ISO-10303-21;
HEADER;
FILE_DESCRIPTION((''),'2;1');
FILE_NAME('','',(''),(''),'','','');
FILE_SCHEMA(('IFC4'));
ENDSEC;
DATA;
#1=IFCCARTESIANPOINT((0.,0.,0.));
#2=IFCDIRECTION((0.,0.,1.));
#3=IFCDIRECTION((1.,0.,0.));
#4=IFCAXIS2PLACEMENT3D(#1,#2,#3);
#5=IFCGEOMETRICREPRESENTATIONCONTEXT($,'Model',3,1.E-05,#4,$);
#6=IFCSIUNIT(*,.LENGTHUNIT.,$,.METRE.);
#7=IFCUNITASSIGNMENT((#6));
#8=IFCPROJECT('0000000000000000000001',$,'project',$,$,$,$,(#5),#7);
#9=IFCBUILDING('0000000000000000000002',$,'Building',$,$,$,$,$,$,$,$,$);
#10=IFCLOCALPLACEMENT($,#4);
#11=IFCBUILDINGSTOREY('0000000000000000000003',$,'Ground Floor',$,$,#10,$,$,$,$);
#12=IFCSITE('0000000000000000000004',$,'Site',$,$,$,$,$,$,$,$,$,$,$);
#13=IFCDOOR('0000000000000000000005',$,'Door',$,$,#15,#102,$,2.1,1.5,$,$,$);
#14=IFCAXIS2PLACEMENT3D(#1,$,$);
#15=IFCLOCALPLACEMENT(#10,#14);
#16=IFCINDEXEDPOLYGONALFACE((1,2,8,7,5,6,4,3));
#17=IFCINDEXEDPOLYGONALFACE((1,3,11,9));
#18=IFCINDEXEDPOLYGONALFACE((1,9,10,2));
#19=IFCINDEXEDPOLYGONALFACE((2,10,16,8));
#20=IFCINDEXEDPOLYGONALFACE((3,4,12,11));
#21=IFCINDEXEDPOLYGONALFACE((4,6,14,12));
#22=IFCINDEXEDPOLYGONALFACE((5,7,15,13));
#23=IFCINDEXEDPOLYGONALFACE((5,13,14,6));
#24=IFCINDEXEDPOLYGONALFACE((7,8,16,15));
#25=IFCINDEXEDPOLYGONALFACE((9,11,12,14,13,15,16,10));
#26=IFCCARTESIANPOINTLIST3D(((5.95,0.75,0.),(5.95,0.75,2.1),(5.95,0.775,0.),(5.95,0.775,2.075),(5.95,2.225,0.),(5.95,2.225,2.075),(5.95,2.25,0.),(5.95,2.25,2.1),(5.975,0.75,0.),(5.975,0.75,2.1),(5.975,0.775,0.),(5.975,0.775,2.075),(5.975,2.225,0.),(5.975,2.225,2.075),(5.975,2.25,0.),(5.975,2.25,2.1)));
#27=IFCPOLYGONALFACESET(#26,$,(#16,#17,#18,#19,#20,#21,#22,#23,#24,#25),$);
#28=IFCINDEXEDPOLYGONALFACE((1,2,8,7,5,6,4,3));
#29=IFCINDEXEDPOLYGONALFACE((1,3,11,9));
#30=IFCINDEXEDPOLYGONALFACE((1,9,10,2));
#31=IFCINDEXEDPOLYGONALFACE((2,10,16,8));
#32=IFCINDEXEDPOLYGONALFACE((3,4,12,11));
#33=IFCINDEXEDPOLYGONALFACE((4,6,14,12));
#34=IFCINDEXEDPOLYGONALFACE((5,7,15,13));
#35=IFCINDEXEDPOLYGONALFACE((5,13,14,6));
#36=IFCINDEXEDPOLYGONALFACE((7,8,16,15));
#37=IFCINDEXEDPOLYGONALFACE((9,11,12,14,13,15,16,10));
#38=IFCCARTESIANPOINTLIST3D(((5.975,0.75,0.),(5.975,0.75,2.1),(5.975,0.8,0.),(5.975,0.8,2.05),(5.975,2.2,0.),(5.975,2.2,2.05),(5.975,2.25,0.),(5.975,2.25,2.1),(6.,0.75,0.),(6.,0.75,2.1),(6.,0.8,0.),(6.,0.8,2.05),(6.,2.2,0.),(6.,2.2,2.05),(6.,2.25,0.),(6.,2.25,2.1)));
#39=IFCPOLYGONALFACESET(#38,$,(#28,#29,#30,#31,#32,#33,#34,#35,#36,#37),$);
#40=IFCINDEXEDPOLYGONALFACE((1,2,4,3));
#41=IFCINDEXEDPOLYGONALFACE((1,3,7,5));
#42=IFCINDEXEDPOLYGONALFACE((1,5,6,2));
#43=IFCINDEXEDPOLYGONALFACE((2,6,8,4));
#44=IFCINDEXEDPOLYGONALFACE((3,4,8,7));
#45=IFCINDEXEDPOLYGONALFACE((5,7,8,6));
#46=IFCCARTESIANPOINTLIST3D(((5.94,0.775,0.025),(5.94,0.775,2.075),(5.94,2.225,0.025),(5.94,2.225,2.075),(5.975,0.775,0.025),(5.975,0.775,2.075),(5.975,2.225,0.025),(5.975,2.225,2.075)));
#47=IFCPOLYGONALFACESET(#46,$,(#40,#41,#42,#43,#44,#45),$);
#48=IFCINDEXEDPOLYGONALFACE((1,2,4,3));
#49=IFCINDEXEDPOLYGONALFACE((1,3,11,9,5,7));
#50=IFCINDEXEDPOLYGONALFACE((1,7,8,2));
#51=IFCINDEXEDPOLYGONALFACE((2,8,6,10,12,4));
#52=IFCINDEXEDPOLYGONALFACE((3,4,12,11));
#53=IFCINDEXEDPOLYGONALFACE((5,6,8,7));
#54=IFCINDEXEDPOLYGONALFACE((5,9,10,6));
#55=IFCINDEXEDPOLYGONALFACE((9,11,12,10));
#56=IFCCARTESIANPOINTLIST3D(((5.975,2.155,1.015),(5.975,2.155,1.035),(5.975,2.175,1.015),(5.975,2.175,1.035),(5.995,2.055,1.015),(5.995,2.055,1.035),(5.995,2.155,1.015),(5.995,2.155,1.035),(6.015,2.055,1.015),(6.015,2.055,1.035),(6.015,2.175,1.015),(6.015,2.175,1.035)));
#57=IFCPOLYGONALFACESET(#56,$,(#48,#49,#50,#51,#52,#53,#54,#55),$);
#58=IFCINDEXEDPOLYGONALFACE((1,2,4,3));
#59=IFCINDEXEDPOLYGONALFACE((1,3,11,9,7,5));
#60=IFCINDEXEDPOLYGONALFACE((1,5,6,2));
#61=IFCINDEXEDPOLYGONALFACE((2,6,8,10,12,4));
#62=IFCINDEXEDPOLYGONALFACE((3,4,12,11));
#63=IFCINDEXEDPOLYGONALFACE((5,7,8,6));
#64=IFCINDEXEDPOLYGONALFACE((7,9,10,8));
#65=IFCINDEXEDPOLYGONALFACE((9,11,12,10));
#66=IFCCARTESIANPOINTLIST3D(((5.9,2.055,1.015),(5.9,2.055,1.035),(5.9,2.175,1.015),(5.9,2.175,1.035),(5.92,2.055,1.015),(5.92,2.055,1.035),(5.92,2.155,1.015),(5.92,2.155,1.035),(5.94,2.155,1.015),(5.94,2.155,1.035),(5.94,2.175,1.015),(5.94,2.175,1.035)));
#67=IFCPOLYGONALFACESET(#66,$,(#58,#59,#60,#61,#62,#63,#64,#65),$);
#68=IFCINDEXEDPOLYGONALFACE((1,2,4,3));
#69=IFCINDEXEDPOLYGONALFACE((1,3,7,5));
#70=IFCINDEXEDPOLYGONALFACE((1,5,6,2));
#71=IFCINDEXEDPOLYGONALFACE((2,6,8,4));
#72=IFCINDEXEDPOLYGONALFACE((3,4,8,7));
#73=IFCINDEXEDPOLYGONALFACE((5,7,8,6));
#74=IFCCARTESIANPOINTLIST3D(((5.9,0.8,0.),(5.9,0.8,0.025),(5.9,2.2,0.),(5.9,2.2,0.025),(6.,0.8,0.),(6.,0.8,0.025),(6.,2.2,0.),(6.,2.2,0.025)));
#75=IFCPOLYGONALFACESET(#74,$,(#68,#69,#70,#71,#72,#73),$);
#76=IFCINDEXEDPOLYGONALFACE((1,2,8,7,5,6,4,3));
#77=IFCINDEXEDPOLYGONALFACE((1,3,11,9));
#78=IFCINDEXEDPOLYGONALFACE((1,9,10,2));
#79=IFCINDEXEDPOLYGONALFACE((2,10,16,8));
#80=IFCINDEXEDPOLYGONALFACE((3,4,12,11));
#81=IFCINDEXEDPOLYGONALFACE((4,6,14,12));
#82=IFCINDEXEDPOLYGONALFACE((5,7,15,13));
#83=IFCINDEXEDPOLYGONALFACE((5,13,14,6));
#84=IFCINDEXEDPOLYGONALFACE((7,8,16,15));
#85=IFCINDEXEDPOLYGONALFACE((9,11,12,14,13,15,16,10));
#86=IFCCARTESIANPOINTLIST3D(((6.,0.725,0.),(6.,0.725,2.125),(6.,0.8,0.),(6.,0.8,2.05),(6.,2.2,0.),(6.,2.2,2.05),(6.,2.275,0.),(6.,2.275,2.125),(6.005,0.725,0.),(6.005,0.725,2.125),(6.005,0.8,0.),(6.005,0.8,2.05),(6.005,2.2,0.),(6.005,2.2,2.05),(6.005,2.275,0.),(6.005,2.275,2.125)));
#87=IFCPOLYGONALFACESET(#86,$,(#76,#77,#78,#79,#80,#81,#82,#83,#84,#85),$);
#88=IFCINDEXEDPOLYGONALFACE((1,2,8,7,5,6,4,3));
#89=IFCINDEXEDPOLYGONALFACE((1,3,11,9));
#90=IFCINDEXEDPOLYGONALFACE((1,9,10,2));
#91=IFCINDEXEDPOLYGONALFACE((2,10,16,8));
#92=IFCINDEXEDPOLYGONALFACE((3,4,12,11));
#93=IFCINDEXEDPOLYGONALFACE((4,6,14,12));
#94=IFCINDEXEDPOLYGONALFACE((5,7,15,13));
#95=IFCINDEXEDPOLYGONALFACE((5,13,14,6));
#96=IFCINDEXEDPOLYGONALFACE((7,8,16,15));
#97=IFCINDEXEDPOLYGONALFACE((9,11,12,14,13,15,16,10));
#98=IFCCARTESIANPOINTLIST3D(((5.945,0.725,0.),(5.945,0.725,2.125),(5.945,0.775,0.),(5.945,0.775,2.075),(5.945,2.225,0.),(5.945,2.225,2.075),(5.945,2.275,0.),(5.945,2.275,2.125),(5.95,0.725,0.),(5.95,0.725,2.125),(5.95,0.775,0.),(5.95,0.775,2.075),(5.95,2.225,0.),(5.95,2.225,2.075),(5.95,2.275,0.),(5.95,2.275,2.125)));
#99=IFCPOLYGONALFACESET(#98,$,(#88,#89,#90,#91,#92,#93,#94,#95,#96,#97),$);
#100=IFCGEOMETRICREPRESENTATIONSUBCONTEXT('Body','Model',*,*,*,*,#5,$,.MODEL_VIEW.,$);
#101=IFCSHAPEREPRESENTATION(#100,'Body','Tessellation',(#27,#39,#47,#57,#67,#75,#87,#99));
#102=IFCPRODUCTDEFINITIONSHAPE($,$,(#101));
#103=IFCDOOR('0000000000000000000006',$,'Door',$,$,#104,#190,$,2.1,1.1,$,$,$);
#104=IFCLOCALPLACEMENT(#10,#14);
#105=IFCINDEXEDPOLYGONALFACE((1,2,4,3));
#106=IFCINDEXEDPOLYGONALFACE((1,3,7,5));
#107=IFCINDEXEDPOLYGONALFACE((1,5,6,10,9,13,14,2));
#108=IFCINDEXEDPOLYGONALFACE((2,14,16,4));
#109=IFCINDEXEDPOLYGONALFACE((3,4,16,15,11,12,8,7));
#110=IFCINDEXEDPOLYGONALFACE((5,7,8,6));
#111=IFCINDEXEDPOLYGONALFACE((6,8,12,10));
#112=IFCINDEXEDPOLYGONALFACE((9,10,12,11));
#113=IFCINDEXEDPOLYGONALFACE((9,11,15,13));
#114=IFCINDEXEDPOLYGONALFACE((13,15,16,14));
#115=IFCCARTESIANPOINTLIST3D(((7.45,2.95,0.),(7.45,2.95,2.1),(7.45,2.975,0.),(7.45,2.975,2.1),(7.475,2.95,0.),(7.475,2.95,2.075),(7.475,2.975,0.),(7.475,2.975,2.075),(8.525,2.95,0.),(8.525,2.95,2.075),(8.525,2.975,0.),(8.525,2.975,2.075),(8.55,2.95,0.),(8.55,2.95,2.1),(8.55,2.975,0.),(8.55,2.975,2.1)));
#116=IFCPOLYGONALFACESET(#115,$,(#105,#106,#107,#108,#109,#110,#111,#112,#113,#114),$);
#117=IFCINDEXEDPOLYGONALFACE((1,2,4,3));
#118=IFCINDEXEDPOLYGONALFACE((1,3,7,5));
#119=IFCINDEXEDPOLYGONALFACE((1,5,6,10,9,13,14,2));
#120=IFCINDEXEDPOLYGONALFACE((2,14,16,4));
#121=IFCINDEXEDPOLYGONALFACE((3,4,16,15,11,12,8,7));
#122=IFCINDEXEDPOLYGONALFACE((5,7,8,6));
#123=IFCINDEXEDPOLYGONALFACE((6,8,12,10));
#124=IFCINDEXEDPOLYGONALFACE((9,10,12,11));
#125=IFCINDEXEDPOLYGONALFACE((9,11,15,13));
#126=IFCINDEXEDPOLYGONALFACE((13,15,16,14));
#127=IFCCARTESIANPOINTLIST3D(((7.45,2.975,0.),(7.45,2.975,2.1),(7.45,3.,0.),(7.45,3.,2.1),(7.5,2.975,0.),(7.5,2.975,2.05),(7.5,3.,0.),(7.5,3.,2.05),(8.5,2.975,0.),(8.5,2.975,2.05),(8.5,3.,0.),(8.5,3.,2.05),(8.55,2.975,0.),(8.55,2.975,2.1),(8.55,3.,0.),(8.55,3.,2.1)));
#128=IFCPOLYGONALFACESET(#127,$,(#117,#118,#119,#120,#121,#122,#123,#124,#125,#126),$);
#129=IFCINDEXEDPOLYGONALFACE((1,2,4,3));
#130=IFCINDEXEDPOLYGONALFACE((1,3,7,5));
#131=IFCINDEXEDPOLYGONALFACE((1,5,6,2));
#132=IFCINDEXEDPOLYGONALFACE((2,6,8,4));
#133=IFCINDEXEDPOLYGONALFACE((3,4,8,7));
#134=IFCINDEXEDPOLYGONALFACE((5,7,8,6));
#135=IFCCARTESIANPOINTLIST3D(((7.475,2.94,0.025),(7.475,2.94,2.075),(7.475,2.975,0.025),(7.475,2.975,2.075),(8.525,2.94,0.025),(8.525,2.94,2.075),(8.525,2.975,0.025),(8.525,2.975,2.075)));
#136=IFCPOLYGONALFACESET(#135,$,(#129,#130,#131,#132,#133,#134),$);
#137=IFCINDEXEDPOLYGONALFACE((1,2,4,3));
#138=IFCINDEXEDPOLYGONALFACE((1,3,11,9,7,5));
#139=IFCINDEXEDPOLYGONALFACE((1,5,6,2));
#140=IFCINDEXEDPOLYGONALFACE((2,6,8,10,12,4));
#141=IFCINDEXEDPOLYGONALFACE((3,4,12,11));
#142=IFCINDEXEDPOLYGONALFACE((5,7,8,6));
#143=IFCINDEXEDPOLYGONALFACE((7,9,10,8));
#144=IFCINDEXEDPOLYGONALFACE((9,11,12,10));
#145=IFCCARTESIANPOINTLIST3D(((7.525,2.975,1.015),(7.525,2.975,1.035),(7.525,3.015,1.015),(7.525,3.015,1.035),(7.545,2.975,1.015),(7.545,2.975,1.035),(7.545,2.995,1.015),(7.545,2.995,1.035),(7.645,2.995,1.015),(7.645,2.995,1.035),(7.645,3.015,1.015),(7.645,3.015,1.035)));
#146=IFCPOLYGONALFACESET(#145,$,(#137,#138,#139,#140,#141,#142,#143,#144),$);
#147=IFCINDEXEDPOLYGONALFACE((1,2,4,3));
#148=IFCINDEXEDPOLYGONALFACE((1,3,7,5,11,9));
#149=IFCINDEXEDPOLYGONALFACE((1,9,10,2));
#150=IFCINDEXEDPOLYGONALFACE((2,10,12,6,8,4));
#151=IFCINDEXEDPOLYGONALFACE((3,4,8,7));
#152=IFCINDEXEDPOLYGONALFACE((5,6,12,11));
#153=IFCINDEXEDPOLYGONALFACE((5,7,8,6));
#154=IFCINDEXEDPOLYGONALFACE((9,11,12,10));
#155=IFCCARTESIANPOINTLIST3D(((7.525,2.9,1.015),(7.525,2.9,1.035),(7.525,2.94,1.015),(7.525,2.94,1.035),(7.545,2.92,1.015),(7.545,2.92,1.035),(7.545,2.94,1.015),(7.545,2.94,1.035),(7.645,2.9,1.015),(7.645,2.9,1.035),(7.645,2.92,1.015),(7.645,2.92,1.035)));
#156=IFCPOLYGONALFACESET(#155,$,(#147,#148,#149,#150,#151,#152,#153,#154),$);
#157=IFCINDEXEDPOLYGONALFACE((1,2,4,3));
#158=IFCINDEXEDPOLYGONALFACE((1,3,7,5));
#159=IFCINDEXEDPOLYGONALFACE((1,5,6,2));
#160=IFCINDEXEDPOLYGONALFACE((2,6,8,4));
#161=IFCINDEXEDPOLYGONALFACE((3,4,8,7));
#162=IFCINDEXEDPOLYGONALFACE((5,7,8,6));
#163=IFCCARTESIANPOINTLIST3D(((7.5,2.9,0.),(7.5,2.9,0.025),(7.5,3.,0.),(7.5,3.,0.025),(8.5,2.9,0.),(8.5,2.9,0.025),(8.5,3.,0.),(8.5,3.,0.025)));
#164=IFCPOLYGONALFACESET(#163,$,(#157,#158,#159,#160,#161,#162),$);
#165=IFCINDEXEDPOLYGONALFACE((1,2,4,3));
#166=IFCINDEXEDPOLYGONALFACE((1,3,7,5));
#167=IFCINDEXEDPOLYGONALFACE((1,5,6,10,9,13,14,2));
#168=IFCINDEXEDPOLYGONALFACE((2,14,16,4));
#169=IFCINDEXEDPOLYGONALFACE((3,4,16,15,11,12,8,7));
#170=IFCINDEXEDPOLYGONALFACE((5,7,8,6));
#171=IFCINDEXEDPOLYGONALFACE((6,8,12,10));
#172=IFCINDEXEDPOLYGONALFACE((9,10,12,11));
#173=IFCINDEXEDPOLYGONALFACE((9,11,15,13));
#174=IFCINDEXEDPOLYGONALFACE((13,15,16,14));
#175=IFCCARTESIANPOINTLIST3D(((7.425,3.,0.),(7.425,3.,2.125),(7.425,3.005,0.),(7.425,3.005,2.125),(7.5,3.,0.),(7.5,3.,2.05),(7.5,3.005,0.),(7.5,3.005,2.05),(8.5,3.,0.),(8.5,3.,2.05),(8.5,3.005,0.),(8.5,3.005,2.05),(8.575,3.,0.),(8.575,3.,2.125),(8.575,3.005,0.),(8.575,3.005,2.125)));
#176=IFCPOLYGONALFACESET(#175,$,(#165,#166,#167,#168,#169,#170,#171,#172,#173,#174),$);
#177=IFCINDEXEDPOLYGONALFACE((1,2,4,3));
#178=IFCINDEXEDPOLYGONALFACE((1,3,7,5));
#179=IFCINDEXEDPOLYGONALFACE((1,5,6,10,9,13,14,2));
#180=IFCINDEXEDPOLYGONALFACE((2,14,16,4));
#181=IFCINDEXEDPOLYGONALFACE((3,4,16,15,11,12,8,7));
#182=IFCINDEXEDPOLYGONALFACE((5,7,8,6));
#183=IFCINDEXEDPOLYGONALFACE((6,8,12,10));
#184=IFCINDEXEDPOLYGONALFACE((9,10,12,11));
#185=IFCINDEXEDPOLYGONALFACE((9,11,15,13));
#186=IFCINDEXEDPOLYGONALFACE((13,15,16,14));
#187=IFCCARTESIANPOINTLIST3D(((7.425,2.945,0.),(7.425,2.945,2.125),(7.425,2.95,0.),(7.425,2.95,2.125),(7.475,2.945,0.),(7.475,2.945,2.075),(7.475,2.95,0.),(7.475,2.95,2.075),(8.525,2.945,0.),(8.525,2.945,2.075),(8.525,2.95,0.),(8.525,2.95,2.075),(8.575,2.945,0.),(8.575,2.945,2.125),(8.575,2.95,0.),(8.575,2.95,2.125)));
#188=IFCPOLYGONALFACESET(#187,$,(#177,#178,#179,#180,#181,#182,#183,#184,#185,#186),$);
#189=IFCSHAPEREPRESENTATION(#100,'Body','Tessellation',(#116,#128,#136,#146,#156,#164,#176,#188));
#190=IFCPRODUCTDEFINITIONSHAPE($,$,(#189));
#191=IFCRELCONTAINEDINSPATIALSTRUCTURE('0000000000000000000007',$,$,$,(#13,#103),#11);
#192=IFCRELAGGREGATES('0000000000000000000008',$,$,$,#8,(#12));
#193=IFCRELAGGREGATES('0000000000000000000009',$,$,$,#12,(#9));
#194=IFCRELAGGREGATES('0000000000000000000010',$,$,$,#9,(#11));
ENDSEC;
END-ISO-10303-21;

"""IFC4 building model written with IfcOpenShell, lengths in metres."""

from ifc_helpers import new_model, si_unit, frame, origin_with_axes, place, context, subcontext, project, spatial, line, indexed_curve, outline, extrude, element, save


model = new_model("IFC4")

# Units and contexts
model_context = context("Model", 3, precision=1e-05, world=origin_with_axes())
body_context = subcontext(model_context, "Body", "Model", "MODEL_VIEW")
ifc_project = project(units=[si_unit("LENGTHUNIT", "METRE")], contexts=[model_context])

# Site, building, storey
site = spatial("IfcSite", under=ifc_project, Name="Site")
building = spatial("IfcBuilding", under=site, Name="Building")
storey_placement = place(None, origin_with_axes())
storey = spatial("IfcBuildingStorey", under=building, at=storey_placement, Name="Ground Floor")

# Doors
door_1_placement = place(storey_placement, frame((6.0, 0.75, 0.0), z_axis=(0.0, 0.0, 1.0), x_axis=(0.0, 1.0, 0.0)))
element("IfcDoor", 1, at=door_1_placement, inside=storey, Name="Door", OverallHeight=2.1, OverallWidth=1.5, context=body_context, shape_type="SweptSolid", body=[
    extrude(outline(indexed_curve([(0.0, 0.0), (0.0, 2.1), (1.5, 2.1), (1.5, 0.0), (1.475, 0.0), (1.475, 2.075), (0.025, 2.075), (0.025, 0.0)], segments=[line(1, 2, 3, 4, 5, 6, 7, 8, 1)])), frame((0.0, 0.025, 0.0), z_axis=(0.0, -1.0, 0.0), x_axis=(1.0, 0.0, 0.0)), (0.0, 0.0, -1.0), 0.025),
    extrude(outline(indexed_curve([(0.0, 0.0), (0.0, 2.1), (1.5, 2.1), (1.5, 0.0), (1.45, 0.0), (1.45, 2.05), (0.05, 2.05), (0.05, 0.0)], segments=[line(1, 2, 3, 4, 5, 6, 7, 8, 1)])), frame((0.0, 0.0, 0.0), z_axis=(0.0, -1.0, 0.0), x_axis=(1.0, 0.0, 0.0)), (0.0, 0.0, -1.0), 0.025),
    extrude(outline(indexed_curve([(0.0, 0.0), (1.45, 0.0), (1.45, 0.035), (0.0, 0.035)], segments=[line(1, 2, 3, 4, 1)])), frame((0.025, 0.025, 0.025), z_axis=(0.0, 0.0, 1.0), x_axis=(1.0, 0.0, 0.0)), (0.0, 0.0, 1.0), 2.05),
    extrude(outline(indexed_curve([(0.0, 0.0), (0.0, -0.04), (-0.12, -0.04), (-0.12, -0.02), (-0.02, -0.02), (-0.02, 0.0)], segments=[line(1, 2, 3, 4, 5, 6, 1)])), frame((1.425, 0.025, 1.015), z_axis=(0.0, 0.0, 1.0), x_axis=(1.0, 0.0, 0.0)), (0.0, 0.0, 1.0), 0.02),
    extrude(outline(indexed_curve([(0.0, 0.0), (0.0, 0.04), (-0.12, 0.04), (-0.12, 0.02), (-0.02, 0.02), (-0.02, 0.0)], segments=[line(1, 2, 3, 4, 5, 6, 1)])), frame((1.425, 0.06, 1.015), z_axis=(0.0, 0.0, 1.0), x_axis=(1.0, 0.0, 0.0)), (0.0, 0.0, 1.0), 0.02),
    extrude(outline(indexed_curve([(0.0, 0.0), (1.4, 0.0), (1.4, 0.1), (0.0, 0.1)], segments=[line(1, 2, 3, 4, 1)])), frame((0.05, 0.0, 0.0), z_axis=(0.0, 0.0, 1.0), x_axis=(1.0, 0.0, 0.0)), (0.0, 0.0, 1.0), 0.025),
    extrude(outline(indexed_curve([(0.0, 0.0), (0.0, 2.125), (1.55, 2.125), (1.55, 0.0), (1.475, 0.0), (1.475, 2.05), (0.075, 2.05), (0.075, 0.0)], segments=[line(1, 2, 3, 4, 5, 6, 7, 8, 1)])), frame((-0.025, -0.005, 0.0), z_axis=(0.0, -1.0, 0.0), x_axis=(1.0, 0.0, 0.0)), (0.0, 0.0, -1.0), 0.005),
    extrude(outline(indexed_curve([(0.0, 0.0), (0.0, 2.125), (1.55, 2.125), (1.55, 0.0), (1.5, 0.0), (1.5, 2.075), (0.05, 2.075), (0.05, 0.0)], segments=[line(1, 2, 3, 4, 5, 6, 7, 8, 1)])), frame((-0.025, 0.05, 0.0), z_axis=(0.0, -1.0, 0.0), x_axis=(1.0, 0.0, 0.0)), (0.0, 0.0, -1.0), 0.005),
])
door_2_placement = place(storey_placement, frame((8.55, 3.0, 0.0), z_axis=(0.0, 0.0, 1.0), x_axis=(-1.0, 0.0, 0.0)))
element("IfcDoor", 2, at=door_2_placement, inside=storey, Name="Door", OverallHeight=2.1, OverallWidth=1.1, context=body_context, shape_type="SweptSolid", body=[
    extrude(outline(indexed_curve([(0.0, 0.0), (0.0, 2.1), (1.1, 2.1), (1.1, 0.0), (1.075, 0.0), (1.075, 2.075), (0.025, 2.075), (0.025, 0.0)], segments=[line(1, 2, 3, 4, 5, 6, 7, 8, 1)])), frame((0.0, 0.025, 0.0), z_axis=(0.0, -1.0, 0.0), x_axis=(1.0, 0.0, 0.0)), (0.0, 0.0, -1.0), 0.025),
    extrude(outline(indexed_curve([(0.0, 0.0), (0.0, 2.1), (1.1, 2.1), (1.1, 0.0), (1.05, 0.0), (1.05, 2.05), (0.05, 2.05), (0.05, 0.0)], segments=[line(1, 2, 3, 4, 5, 6, 7, 8, 1)])), frame((0.0, 0.0, 0.0), z_axis=(0.0, -1.0, 0.0), x_axis=(1.0, 0.0, 0.0)), (0.0, 0.0, -1.0), 0.025),
    extrude(outline(indexed_curve([(0.0, 0.0), (1.05, 0.0), (1.05, 0.035), (0.0, 0.035)], segments=[line(1, 2, 3, 4, 1)])), frame((0.025, 0.025, 0.025), z_axis=(0.0, 0.0, 1.0), x_axis=(1.0, 0.0, 0.0)), (0.0, 0.0, 1.0), 2.05),
    extrude(outline(indexed_curve([(0.0, 0.0), (0.0, -0.04), (-0.12, -0.04), (-0.12, -0.02), (-0.02, -0.02), (-0.02, 0.0)], segments=[line(1, 2, 3, 4, 5, 6, 1)])), frame((1.025, 0.025, 1.015), z_axis=(0.0, 0.0, 1.0), x_axis=(1.0, 0.0, 0.0)), (0.0, 0.0, 1.0), 0.02),
    extrude(outline(indexed_curve([(0.0, 0.0), (0.0, 0.04), (-0.12, 0.04), (-0.12, 0.02), (-0.02, 0.02), (-0.02, 0.0)], segments=[line(1, 2, 3, 4, 5, 6, 1)])), frame((1.025, 0.06, 1.015), z_axis=(0.0, 0.0, 1.0), x_axis=(1.0, 0.0, 0.0)), (0.0, 0.0, 1.0), 0.02),
    extrude(outline(indexed_curve([(0.0, 0.0), (1.0, 0.0), (1.0, 0.1), (0.0, 0.1)], segments=[line(1, 2, 3, 4, 1)])), frame((0.05, 0.0, 0.0), z_axis=(0.0, 0.0, 1.0), x_axis=(1.0, 0.0, 0.0)), (0.0, 0.0, 1.0), 0.025),
    extrude(outline(indexed_curve([(0.0, 0.0), (0.0, 2.125), (1.15, 2.125), (1.15, 0.0), (1.075, 0.0), (1.075, 2.05), (0.075, 2.05), (0.075, 0.0)], segments=[line(1, 2, 3, 4, 5, 6, 7, 8, 1)])), frame((-0.025, -0.005, 0.0), z_axis=(0.0, -1.0, 0.0), x_axis=(1.0, 0.0, 0.0)), (0.0, 0.0, -1.0), 0.005),
    extrude(outline(indexed_curve([(0.0, 0.0), (0.0, 2.125), (1.15, 2.125), (1.15, 0.0), (1.1, 0.0), (1.1, 2.075), (0.05, 2.075), (0.05, 0.0)], segments=[line(1, 2, 3, 4, 5, 6, 7, 8, 1)])), frame((-0.025, 0.05, 0.0), z_axis=(0.0, -1.0, 0.0), x_axis=(1.0, 0.0, 0.0)), (0.0, 0.0, -1.0), 0.005),
])

save(model, "model.ifc")
